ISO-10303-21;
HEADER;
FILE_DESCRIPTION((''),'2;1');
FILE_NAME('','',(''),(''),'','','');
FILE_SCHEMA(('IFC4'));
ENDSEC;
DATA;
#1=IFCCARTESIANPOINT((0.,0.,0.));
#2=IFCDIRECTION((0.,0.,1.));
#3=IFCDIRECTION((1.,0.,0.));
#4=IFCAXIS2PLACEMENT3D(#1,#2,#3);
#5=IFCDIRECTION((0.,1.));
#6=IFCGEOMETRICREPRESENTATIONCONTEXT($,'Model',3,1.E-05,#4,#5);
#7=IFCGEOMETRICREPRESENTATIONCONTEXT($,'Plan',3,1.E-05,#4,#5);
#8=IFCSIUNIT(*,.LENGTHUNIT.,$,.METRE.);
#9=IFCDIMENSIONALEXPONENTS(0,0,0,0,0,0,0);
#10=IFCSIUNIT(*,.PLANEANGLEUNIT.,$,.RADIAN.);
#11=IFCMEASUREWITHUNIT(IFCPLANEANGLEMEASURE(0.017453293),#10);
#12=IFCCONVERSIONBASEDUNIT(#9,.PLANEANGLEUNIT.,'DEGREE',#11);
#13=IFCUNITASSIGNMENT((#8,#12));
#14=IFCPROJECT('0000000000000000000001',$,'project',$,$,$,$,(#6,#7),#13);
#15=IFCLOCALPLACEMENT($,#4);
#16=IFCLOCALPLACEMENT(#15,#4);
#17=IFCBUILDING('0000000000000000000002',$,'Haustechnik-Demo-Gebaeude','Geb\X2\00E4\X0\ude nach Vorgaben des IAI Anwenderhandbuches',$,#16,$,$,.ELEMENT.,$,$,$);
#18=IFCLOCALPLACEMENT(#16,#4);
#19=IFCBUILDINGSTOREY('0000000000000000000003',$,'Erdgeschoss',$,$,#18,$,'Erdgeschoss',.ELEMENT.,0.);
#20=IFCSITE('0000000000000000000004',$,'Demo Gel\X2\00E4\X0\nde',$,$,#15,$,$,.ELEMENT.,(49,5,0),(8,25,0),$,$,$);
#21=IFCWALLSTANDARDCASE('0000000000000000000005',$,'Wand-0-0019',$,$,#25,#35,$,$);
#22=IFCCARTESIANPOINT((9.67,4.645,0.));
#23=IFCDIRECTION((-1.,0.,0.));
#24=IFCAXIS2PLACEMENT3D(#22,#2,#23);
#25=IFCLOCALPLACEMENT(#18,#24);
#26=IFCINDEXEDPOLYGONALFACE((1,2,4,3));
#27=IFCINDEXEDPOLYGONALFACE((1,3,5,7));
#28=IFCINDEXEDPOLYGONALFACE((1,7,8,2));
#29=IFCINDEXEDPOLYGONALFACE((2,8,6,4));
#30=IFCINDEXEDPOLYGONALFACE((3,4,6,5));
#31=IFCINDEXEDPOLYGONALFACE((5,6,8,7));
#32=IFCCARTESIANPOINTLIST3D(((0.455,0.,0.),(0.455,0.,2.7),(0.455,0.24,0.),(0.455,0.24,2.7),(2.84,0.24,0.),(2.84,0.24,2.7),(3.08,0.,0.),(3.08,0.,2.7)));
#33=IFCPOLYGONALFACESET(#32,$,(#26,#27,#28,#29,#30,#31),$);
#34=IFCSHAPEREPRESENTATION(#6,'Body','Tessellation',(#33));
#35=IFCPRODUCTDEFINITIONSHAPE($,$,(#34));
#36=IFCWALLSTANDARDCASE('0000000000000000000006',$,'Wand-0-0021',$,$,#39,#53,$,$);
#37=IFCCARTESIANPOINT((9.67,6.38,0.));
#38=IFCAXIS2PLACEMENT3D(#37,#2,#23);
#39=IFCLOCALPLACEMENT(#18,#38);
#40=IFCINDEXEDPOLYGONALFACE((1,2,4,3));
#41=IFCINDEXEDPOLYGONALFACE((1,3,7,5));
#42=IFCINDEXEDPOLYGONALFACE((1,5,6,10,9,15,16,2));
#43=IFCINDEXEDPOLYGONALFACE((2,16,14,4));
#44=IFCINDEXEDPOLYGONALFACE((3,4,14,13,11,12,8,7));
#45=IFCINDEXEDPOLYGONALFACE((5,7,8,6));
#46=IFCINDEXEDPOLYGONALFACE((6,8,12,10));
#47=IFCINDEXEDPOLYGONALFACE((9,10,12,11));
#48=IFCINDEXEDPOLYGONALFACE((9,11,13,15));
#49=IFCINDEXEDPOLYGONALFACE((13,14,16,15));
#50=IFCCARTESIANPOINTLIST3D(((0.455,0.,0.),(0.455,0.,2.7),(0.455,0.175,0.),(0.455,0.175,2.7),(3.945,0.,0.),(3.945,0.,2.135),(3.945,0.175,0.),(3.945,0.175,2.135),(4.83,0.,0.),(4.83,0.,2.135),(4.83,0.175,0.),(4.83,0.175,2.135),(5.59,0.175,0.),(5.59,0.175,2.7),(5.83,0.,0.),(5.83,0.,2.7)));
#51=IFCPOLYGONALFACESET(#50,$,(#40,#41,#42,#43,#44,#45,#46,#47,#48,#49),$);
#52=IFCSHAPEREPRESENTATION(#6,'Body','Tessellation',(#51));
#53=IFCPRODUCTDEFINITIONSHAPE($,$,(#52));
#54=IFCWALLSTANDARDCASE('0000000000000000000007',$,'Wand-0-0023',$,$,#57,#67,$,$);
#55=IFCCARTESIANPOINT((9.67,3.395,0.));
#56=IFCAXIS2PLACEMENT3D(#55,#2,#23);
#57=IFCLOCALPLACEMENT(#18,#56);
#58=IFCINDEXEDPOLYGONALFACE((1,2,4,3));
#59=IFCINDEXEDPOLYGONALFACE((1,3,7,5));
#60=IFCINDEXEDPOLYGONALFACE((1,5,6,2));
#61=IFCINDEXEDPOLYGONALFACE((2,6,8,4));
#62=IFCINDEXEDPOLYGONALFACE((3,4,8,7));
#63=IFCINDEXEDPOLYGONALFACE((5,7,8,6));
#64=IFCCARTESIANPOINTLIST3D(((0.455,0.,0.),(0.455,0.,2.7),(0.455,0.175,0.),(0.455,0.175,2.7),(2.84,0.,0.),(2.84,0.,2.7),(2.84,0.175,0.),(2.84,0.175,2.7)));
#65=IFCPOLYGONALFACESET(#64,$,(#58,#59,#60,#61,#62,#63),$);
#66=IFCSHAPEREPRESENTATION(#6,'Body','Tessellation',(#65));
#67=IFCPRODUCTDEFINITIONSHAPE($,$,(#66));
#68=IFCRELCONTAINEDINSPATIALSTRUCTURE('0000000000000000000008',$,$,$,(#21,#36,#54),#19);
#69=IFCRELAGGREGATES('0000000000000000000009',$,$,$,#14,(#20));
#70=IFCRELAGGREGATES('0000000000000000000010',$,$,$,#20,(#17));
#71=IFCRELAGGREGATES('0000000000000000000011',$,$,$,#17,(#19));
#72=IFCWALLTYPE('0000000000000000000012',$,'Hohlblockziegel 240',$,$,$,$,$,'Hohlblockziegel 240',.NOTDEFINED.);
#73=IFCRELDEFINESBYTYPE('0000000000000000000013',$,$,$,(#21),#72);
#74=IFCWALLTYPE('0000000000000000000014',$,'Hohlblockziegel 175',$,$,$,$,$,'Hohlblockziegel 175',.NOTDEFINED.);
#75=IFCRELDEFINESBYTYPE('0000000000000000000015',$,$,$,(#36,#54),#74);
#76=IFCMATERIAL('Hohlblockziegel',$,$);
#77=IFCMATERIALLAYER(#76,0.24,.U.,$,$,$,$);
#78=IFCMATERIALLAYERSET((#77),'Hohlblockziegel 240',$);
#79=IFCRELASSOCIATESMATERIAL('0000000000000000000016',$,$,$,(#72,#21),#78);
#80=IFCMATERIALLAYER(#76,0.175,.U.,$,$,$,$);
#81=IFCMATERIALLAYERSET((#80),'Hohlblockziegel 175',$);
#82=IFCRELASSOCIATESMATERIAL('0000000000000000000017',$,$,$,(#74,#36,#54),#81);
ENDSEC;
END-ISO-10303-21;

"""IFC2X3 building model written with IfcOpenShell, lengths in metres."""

from ifc_helpers import new_model, entity, si_unit, converted_unit, direction, frame, frame_2d, origin_with_axes, place, context, project, spatial, polyline, rectangle, outline, extrude, material, layer, layer_set, layer_usage, type_object, element, save


model = new_model("IFC2X3")

# Units and contexts
model_context = context("Model", 3, precision=1e-05, world=origin_with_axes(), true_north=direction((0.0, 1.0)))
plan_context = context("Plan", 3, precision=1e-05, world=origin_with_axes(), true_north=direction((0.0, 1.0)))
ifc_project = project(units=[si_unit("LENGTHUNIT", "METRE"), converted_unit("PLANEANGLEUNIT", "DEGREE", entity("IfcPlaneAngleMeasure", 0.017453293), si_unit("PLANEANGLEUNIT", "RADIAN"), dimensions=[0, 0, 0, 0, 0, 0, 0])], contexts=[model_context, plan_context])

# Site, building, storey
site_placement = place(None, origin_with_axes())
site = spatial("IfcSite", under=ifc_project, at=site_placement, Name="Demo Gelände", CompositionType="ELEMENT", RefLatitude=(49, 5, 0), RefLongitude=(8, 25, 0))
building_placement = place(site_placement, origin_with_axes())
building = spatial("IfcBuilding", under=site, at=building_placement, Name="Haustechnik-Demo-Gebaeude", Description="Gebäude nach Vorgaben des IAI Anwenderhandbuches", CompositionType="ELEMENT")
storey_placement = place(building_placement, origin_with_axes())
storey = spatial("IfcBuildingStorey", under=building, at=storey_placement, Name="Erdgeschoss", LongName="Erdgeschoss", CompositionType="ELEMENT", Elevation=0.0)

# Shared definitions
ifc_material_1 = material(Name="Hohlblockziegel")
ifc_layer_1 = layer(ifc_material_1, 0.24, ventilated="UNKNOWN")
ifc_layer_set_1 = layer_set([ifc_layer_1], Name="Hohlblockziegel 240")
wall_type_1 = type_object("IfcWallType", Name="Hohlblockziegel 240", ElementType="Hohlblockziegel 240", PredefinedType="NOTDEFINED", material=ifc_layer_set_1)

# Wall
ifc_layer_usage_1 = layer_usage(ifc_layer_set_1, "AXIS2", "POSITIVE", 0.0)
wall_1_placement = place(storey_placement, frame((9.67, 4.645, 0.0), z_axis=(0.0, 0.0, 1.0), x_axis=(-1.0, 0.0, 0.0)))
element("IfcWallStandardCase", 1, at=wall_1_placement, inside=storey, type_object=wall_type_1, material=ifc_layer_usage_1, Name="Wand-0-0019", context=model_context, shape_type="SweptSolid", body=[
    extrude(outline(polyline([(0.455, 0.0), (3.08, 0.0), (2.84, 0.24), (0.455, 0.24), (0.455, 0.0)])), origin_with_axes(), (0.0, 0.0, 1.0), 2.7),
])

# Wall, opening
ifc_layer_2 = layer(ifc_material_1, 0.175, ventilated="UNKNOWN")
ifc_layer_set_2 = layer_set([ifc_layer_2], Name="Hohlblockziegel 175")
ifc_layer_usage_2 = layer_usage(ifc_layer_set_2, "AXIS2", "POSITIVE", 0.0)
wall_type_2 = type_object("IfcWallType", Name="Hohlblockziegel 175", ElementType="Hohlblockziegel 175", PredefinedType="NOTDEFINED", material=ifc_layer_set_2)
wall_2_placement = place(storey_placement, frame((9.67, 6.38, 0.0), z_axis=(0.0, 0.0, 1.0), x_axis=(-1.0, 0.0, 0.0)))
wall_2 = element("IfcWallStandardCase", 2, at=wall_2_placement, inside=storey, type_object=wall_type_2, material=ifc_layer_usage_2, Name="Wand-0-0021", context=model_context, shape_type="SweptSolid", body=[
    extrude(outline(polyline([(0.455, 0.0), (5.83, 0.0), (5.59, 0.175), (0.455, 0.175), (0.455, 0.0)])), origin_with_axes(), (0.0, 0.0, 1.0), 2.7),
])
opening_1_placement = place(wall_2_placement, frame((4.3875, 0.0, 0.0), z_axis=(0.0, 0.0, 1.0), x_axis=(1.0, 0.0, 0.0)))
element("IfcOpeningElement", 3, at=opening_1_placement, cuts=wall_2, ObjectType="Opening", context=model_context, shape_type="SweptSolid", body=[
    extrude(rectangle(XDim=0.885, YDim=2.135, at=frame_2d((0.0, 1.0675), x_axis=(-1.0, 0.0))), frame((0.0, 0.0, 0.0), z_axis=(0.0, 1.0, 0.0), x_axis=(-1.0, 0.0, 0.0)), (0.0, 0.0, 1.0), 0.175),
])

# Wall
ifc_layer_usage_3 = layer_usage(ifc_layer_set_2, "AXIS2", "POSITIVE", 0.0)
wall_3_placement = place(storey_placement, frame((9.67, 3.395, 0.0), z_axis=(0.0, 0.0, 1.0), x_axis=(-1.0, 0.0, 0.0)))
element("IfcWallStandardCase", 4, at=wall_3_placement, inside=storey, type_object=wall_type_2, material=ifc_layer_usage_3, Name="Wand-0-0023", context=model_context, shape_type="SweptSolid", body=[
    extrude(outline(polyline([(0.455, 0.0), (2.84, 0.0), (2.84, 0.175), (0.455, 0.175), (0.455, 0.0)])), origin_with_axes(), (0.0, 0.0, 1.0), 2.7),
])

save(model, "model.ifc")
